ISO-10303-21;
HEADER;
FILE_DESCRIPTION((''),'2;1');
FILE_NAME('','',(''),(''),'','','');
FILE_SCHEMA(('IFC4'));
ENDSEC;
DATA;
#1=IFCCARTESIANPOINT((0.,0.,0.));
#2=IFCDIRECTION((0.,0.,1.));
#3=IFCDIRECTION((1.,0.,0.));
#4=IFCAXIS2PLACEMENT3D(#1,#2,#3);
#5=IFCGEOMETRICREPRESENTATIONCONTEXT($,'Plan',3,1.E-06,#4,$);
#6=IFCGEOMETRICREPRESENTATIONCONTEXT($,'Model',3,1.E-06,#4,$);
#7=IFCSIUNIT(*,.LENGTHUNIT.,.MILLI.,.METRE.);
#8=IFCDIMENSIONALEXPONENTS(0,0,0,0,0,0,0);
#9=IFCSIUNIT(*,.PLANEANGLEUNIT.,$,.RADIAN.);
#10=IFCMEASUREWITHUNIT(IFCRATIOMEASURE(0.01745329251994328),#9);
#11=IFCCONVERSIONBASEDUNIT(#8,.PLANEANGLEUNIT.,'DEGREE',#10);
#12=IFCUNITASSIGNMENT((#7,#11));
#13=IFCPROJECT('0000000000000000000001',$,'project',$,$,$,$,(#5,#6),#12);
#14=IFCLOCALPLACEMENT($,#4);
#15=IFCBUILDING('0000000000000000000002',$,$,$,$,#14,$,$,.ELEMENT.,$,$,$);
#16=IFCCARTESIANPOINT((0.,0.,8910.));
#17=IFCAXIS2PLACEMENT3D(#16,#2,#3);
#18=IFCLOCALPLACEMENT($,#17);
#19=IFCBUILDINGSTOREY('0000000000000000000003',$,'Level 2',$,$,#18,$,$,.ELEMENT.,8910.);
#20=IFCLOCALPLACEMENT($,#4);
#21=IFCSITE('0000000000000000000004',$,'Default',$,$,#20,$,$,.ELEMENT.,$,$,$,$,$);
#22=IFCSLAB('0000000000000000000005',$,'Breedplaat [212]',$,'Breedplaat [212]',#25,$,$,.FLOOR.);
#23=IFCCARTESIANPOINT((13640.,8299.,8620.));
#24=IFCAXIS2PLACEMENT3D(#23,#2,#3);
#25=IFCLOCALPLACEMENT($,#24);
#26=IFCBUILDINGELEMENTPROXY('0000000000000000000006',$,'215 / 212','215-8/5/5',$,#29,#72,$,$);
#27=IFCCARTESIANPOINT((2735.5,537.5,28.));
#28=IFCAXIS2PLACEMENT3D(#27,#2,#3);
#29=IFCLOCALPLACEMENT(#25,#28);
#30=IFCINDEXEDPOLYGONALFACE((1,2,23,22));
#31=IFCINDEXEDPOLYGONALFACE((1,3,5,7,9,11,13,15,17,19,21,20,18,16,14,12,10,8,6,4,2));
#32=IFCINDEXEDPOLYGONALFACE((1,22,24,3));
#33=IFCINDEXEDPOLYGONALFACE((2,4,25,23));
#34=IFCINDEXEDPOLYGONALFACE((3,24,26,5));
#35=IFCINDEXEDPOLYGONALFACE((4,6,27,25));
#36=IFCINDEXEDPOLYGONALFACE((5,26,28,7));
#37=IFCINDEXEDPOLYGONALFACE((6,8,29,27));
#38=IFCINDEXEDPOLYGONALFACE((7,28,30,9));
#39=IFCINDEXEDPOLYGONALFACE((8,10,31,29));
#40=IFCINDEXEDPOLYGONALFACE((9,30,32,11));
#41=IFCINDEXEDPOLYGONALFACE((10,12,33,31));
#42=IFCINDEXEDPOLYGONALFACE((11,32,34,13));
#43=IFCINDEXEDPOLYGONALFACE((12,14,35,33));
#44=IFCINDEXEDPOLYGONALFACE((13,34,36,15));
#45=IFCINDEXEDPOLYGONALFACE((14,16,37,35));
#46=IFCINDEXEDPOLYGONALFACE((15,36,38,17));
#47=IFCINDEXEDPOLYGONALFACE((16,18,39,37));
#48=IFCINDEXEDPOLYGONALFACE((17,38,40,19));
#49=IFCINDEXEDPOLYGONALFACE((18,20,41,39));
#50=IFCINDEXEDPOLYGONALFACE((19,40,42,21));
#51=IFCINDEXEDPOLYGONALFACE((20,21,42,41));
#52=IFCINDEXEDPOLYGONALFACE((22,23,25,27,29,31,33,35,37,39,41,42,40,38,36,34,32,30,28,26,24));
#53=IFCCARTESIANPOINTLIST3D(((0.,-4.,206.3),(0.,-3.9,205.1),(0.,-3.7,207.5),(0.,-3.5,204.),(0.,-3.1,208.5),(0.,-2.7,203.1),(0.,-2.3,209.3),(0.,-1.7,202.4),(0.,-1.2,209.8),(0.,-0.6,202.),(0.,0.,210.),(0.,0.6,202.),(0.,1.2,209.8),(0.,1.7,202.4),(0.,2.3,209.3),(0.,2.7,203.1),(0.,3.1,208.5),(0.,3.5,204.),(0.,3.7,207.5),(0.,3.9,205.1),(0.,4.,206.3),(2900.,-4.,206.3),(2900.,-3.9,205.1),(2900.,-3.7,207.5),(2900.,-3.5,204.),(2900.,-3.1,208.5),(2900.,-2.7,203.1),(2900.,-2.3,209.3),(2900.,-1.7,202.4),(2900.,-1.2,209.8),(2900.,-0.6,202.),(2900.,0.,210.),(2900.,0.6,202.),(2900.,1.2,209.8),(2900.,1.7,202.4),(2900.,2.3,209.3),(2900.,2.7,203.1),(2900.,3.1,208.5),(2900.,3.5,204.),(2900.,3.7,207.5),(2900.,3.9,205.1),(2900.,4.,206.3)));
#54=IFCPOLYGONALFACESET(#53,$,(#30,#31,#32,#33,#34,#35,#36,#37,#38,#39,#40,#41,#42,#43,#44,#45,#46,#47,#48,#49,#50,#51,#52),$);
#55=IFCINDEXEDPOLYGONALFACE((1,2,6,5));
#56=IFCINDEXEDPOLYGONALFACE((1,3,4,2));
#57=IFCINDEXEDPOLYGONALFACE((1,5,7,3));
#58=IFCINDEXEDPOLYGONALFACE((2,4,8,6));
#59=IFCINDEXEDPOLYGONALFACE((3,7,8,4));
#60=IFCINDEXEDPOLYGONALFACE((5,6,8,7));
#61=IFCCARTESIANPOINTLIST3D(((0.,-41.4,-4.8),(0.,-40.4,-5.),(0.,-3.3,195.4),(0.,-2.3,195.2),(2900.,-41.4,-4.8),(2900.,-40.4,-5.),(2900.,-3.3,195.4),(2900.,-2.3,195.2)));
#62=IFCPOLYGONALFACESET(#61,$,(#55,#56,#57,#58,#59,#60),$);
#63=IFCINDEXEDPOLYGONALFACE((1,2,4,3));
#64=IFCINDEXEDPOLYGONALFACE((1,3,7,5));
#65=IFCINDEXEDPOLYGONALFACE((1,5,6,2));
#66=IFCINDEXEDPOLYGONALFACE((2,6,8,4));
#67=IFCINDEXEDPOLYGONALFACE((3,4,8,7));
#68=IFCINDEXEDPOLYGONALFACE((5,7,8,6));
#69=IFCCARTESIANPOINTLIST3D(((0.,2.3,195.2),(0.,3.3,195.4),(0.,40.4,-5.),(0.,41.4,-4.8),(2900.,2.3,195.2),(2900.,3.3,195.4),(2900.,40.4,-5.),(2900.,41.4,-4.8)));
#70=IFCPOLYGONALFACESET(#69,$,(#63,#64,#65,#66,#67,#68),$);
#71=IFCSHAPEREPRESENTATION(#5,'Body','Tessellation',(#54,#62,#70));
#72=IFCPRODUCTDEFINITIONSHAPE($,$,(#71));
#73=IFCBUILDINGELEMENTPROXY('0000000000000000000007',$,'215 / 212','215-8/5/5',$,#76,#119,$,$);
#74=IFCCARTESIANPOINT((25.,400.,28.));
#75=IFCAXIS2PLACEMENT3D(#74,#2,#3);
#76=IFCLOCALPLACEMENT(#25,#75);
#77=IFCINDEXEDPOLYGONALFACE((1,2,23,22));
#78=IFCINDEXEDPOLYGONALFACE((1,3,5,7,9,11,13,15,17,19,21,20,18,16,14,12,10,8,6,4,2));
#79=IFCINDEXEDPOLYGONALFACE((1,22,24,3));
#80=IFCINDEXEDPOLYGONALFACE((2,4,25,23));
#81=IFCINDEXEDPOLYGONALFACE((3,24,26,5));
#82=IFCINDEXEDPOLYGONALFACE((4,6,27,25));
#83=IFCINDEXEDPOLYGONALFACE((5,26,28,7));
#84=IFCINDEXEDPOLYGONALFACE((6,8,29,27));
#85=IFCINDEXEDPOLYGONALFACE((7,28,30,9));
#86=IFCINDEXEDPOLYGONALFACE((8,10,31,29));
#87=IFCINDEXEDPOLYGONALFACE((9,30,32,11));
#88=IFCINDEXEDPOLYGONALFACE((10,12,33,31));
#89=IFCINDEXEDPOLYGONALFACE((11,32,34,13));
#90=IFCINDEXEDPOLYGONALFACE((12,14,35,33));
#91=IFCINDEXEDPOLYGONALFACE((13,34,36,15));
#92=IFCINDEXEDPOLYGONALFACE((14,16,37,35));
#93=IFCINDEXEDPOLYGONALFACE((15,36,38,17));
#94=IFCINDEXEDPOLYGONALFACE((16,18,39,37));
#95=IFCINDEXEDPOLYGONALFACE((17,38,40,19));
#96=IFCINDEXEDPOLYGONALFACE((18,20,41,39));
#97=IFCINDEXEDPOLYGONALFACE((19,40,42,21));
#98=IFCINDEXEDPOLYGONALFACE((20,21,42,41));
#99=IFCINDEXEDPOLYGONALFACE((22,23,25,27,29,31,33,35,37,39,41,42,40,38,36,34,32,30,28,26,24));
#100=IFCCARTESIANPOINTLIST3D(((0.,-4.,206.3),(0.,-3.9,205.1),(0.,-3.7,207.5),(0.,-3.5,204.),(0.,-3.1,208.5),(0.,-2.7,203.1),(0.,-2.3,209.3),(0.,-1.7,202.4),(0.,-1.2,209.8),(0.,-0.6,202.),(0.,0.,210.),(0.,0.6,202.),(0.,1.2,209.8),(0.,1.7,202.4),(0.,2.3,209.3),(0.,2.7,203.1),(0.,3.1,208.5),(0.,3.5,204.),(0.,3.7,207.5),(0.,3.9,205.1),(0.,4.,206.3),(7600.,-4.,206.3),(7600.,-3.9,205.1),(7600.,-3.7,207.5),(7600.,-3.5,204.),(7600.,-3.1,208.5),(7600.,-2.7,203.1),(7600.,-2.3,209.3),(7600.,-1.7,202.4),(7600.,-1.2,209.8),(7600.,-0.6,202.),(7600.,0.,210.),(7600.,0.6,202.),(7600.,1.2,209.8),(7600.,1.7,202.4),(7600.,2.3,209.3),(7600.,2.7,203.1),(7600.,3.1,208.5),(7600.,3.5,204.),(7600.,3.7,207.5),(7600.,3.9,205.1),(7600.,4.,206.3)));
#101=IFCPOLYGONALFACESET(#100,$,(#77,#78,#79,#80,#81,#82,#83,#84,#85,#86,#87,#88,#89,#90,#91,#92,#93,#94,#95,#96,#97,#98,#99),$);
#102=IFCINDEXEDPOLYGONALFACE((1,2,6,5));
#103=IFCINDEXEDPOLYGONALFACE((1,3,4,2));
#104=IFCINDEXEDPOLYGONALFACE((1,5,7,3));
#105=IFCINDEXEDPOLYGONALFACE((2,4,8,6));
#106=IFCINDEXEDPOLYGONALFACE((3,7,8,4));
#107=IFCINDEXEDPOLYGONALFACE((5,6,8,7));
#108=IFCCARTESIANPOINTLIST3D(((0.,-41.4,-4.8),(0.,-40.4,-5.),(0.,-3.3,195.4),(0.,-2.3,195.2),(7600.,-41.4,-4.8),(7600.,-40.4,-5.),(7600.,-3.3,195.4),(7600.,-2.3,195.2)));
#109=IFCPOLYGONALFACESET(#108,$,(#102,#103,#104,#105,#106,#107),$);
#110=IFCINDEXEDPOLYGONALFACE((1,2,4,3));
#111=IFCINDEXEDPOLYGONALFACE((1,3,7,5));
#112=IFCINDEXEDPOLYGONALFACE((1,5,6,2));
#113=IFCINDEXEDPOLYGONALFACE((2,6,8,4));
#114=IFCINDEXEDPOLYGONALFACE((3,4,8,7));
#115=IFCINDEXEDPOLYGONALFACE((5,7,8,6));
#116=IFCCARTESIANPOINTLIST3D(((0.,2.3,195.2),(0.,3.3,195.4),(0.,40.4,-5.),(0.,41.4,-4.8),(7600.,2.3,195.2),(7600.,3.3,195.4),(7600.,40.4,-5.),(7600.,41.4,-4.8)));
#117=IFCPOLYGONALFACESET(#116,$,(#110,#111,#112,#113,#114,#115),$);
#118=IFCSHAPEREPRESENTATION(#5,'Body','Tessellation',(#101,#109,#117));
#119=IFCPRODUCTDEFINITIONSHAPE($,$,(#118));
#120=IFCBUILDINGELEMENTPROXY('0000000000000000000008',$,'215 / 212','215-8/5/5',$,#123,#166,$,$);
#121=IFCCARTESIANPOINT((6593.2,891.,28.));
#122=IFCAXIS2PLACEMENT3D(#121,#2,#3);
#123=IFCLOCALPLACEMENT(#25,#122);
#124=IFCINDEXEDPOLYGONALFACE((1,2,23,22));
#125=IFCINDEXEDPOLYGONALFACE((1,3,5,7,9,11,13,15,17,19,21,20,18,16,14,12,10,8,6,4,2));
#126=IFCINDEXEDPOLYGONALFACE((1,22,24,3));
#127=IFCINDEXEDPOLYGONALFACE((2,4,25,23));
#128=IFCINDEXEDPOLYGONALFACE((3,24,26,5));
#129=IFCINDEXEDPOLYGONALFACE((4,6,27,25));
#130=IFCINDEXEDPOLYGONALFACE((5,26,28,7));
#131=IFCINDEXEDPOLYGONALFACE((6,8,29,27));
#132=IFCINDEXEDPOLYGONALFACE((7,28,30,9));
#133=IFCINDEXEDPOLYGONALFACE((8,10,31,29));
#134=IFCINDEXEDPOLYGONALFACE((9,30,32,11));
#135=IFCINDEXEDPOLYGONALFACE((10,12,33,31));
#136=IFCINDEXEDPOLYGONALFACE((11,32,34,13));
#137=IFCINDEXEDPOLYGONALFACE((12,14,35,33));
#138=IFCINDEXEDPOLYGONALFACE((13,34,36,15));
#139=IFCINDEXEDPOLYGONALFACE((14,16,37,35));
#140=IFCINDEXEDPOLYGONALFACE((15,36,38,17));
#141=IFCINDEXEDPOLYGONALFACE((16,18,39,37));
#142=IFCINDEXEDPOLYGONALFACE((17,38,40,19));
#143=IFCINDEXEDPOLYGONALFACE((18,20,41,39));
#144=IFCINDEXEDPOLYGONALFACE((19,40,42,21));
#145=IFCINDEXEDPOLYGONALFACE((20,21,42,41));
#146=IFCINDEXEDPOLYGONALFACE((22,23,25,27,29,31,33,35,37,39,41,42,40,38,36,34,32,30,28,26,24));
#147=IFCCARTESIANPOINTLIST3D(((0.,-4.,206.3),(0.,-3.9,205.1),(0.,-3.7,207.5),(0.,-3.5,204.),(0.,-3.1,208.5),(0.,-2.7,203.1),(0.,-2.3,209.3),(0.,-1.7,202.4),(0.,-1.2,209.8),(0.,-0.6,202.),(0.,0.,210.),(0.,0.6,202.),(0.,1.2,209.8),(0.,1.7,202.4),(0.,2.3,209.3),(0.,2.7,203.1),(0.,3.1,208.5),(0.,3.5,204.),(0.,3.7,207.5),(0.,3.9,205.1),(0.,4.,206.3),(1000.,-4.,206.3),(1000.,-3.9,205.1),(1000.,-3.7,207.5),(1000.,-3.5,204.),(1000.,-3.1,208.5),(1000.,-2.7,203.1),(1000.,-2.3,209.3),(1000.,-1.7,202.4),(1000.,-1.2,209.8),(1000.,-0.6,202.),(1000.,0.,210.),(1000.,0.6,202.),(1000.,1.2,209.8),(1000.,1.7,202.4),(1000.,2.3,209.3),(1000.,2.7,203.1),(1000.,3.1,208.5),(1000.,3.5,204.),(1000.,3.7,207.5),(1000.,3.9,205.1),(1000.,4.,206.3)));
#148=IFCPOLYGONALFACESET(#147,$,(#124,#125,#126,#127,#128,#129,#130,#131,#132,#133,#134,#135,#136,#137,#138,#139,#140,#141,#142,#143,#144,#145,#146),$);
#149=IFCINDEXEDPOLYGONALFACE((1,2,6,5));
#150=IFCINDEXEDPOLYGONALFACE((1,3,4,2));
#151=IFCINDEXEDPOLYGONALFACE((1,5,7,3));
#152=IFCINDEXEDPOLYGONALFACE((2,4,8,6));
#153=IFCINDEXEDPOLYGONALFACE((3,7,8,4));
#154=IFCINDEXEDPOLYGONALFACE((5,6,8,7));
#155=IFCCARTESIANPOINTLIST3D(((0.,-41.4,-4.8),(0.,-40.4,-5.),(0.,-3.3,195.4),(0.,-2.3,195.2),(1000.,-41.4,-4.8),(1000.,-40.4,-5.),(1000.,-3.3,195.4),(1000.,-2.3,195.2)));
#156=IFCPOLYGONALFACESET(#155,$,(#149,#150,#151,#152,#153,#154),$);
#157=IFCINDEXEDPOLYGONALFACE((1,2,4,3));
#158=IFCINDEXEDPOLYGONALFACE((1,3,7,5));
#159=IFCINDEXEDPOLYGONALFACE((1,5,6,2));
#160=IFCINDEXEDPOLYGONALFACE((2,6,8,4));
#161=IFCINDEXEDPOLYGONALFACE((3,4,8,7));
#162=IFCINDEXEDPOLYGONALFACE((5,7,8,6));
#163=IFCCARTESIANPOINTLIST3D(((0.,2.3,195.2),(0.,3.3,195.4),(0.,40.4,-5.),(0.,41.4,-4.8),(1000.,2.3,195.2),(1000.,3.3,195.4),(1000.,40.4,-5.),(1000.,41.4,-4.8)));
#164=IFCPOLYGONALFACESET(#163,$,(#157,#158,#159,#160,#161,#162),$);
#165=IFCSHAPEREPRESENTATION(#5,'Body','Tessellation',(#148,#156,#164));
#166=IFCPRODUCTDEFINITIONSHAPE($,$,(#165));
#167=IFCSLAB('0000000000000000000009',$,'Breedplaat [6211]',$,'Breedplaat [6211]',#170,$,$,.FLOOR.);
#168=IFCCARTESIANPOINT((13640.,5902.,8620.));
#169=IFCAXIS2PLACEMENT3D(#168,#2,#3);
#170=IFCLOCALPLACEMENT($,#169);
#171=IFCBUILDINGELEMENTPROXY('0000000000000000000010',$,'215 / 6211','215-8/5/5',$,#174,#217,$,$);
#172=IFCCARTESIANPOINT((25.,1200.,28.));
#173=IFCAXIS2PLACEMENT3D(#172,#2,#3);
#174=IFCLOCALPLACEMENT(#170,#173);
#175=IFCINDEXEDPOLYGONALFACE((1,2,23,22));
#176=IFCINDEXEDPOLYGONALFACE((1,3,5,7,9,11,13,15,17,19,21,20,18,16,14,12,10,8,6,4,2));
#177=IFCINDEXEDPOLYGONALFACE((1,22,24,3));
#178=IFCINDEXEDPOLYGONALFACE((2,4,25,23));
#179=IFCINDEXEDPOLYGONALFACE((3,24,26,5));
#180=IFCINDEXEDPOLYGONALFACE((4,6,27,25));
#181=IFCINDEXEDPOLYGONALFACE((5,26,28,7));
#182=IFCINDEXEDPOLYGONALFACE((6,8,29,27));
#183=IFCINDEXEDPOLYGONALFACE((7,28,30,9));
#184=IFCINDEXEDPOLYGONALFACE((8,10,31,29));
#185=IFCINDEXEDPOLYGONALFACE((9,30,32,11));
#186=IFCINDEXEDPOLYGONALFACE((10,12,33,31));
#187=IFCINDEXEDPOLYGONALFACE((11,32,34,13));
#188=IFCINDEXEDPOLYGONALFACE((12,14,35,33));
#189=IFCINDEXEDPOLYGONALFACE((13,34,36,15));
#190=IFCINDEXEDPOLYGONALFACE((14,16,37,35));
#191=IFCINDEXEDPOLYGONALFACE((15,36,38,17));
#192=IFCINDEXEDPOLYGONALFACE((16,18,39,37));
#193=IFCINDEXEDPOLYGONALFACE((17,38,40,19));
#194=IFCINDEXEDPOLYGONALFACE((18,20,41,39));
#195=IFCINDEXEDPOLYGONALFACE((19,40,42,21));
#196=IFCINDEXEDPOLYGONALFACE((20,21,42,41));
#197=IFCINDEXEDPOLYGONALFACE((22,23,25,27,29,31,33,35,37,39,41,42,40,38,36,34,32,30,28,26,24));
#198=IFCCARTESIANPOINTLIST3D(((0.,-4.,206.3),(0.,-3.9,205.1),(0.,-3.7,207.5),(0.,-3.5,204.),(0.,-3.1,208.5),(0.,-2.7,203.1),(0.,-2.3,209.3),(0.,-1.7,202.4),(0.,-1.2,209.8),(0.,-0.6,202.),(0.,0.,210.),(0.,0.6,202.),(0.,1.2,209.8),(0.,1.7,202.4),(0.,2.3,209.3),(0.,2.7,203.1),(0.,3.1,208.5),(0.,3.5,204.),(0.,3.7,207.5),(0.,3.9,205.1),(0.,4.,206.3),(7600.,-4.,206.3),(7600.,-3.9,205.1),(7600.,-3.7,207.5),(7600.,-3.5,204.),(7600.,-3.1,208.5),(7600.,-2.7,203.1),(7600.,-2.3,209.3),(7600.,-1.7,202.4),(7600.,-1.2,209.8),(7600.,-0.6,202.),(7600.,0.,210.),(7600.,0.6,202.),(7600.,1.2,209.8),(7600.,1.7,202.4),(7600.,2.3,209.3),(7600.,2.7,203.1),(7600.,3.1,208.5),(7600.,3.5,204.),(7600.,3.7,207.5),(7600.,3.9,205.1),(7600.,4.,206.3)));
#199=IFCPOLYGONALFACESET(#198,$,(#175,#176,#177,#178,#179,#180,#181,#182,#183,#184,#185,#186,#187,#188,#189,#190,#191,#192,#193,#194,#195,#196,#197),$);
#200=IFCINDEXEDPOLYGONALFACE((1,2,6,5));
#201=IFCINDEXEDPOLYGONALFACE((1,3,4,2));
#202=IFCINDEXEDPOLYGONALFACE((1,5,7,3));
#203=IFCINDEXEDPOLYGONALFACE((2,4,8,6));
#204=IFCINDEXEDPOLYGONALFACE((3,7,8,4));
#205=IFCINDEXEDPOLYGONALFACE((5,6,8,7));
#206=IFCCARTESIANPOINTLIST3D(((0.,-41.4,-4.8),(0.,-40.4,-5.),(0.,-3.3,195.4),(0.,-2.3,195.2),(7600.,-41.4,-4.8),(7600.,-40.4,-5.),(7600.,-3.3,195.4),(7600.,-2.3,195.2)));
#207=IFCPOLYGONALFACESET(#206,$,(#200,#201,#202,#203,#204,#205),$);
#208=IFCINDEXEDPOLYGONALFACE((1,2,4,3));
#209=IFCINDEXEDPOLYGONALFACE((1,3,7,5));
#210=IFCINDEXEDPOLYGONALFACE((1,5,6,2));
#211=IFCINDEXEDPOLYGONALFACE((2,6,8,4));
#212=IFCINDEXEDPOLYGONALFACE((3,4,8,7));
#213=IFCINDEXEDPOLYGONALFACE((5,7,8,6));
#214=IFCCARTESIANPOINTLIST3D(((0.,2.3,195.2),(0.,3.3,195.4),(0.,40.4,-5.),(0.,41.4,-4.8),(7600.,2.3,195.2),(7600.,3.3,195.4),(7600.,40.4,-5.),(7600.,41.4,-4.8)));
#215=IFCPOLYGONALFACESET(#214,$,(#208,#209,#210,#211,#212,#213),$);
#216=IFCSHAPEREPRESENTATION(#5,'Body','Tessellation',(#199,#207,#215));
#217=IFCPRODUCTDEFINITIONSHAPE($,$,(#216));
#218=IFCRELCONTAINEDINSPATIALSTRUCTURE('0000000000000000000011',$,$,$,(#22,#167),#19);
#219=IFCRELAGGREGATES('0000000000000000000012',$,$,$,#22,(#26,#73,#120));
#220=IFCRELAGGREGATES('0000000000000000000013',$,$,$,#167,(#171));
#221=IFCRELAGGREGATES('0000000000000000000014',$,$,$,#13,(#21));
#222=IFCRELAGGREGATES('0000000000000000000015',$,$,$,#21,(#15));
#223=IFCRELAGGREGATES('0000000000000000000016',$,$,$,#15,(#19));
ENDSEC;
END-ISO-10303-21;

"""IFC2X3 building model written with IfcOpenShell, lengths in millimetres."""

from ifc_helpers import new_model, entity, si_unit, converted_unit, frame, origin_with_axes, origin_2d_with_axis, place, context, project, spatial, rectangle, circle, extrude, element, aggregate, save


model = new_model("IFC2X3")

# Units and contexts
plan_context = context("Plan", 3, precision=1e-06, world=origin_with_axes())
model_context = context("Model", 3, precision=1e-06, world=origin_with_axes())
ifc_project = project(units=[si_unit("LENGTHUNIT", "METRE", prefix="MILLI"), converted_unit("PLANEANGLEUNIT", "DEGREE", entity("IfcRatioMeasure", 0.01745329251994328), si_unit("PLANEANGLEUNIT", "RADIAN"), dimensions=[0, 0, 0, 0, 0, 0, 0])], contexts=[plan_context, model_context])

# Site, building, storey
site_placement = place(None, origin_with_axes())
site = spatial("IfcSite", under=ifc_project, at=site_placement, Name="Default", CompositionType="ELEMENT")
building_placement = place(None, origin_with_axes())
building = spatial("IfcBuilding", under=site, at=building_placement, CompositionType="ELEMENT")
storey_placement = place(None, frame((0.0, 0.0, 8910.0), z_axis=(0.0, 0.0, 1.0), x_axis=(1.0, 0.0, 0.0)))
storey = spatial("IfcBuildingStorey", under=building, at=storey_placement, Name="Level 2", CompositionType="ELEMENT", Elevation=8910.0)

# Slab, building element proxies
slab_1_placement = place(None, frame((13640.0, 8299.0, 8620.0), z_axis=(0.0, 0.0, 1.0), x_axis=(1.0, 0.0, 0.0)))
slab_1 = element("IfcSlab", 1, at=slab_1_placement, inside=storey, Name="Breedplaat [212]", ObjectType="Breedplaat [212]", PredefinedType="FLOOR")
proxy_1_placement = place(slab_1_placement, frame((2735.5, 537.5, 28.0), z_axis=(0.0, 0.0, 1.0), x_axis=(1.0, 0.0, 0.0)))
proxy_1 = element("IfcBuildingElementProxy", 2, at=proxy_1_placement, Name="215 / 212", Description="215-8/5/5", context=plan_context, shape_type="SweptSolid", body=[
    extrude(circle(Radius=4.0, at=origin_2d_with_axis()), frame((0.0, 0.0, 206.0), z_axis=(1.0, 0.0, 0.0), x_axis=(0.0, 0.0, 1.0)), (0.0, 0.0, 1.0), 2900.0),
    extrude(rectangle(XDim=203.8, YDim=1.0, at=origin_2d_with_axis()), frame((0.0, -21.9, 95.2), z_axis=(1.0, 0.0, 0.0), x_axis=(0.0, 0.187112, 0.982339)), (0.0, 0.0, 1.0), 2900.0),
    extrude(rectangle(XDim=203.8, YDim=1.0, at=origin_2d_with_axis()), frame((0.0, 21.9, 95.2), z_axis=(1.0, 0.0, 0.0), x_axis=(0.0, -0.187112, 0.982339)), (0.0, 0.0, 1.0), 2900.0),
])
proxy_2_placement = place(slab_1_placement, frame((25.0, 400.0, 28.0), z_axis=(0.0, 0.0, 1.0), x_axis=(1.0, 0.0, 0.0)))
proxy_2 = element("IfcBuildingElementProxy", 3, at=proxy_2_placement, Name="215 / 212", Description="215-8/5/5", context=plan_context, shape_type="SweptSolid", body=[
    extrude(circle(Radius=4.0, at=origin_2d_with_axis()), frame((0.0, 0.0, 206.0), z_axis=(1.0, 0.0, 0.0), x_axis=(0.0, 0.0, 1.0)), (0.0, 0.0, 1.0), 7600.0),
    extrude(rectangle(XDim=203.8, YDim=1.0, at=origin_2d_with_axis()), frame((0.0, -21.9, 95.2), z_axis=(1.0, 0.0, 0.0), x_axis=(0.0, 0.187112, 0.982339)), (0.0, 0.0, 1.0), 7600.0),
    extrude(rectangle(XDim=203.8, YDim=1.0, at=origin_2d_with_axis()), frame((0.0, 21.9, 95.2), z_axis=(1.0, 0.0, 0.0), x_axis=(0.0, -0.187112, 0.982339)), (0.0, 0.0, 1.0), 7600.0),
])
proxy_3_placement = place(slab_1_placement, frame((6593.2, 891.0, 28.0), z_axis=(0.0, 0.0, 1.0), x_axis=(1.0, 0.0, 0.0)))
proxy_3 = element("IfcBuildingElementProxy", 4, at=proxy_3_placement, Name="215 / 212", Description="215-8/5/5", context=plan_context, shape_type="SweptSolid", body=[
    extrude(circle(Radius=4.0, at=origin_2d_with_axis()), frame((0.0, 0.0, 206.0), z_axis=(1.0, 0.0, 0.0), x_axis=(0.0, 0.0, 1.0)), (0.0, 0.0, 1.0), 1000.0),
    extrude(rectangle(XDim=203.8, YDim=1.0, at=origin_2d_with_axis()), frame((0.0, -21.9, 95.2), z_axis=(1.0, 0.0, 0.0), x_axis=(0.0, 0.187112, 0.982339)), (0.0, 0.0, 1.0), 1000.0),
    extrude(rectangle(XDim=203.8, YDim=1.0, at=origin_2d_with_axis()), frame((0.0, 21.9, 95.2), z_axis=(1.0, 0.0, 0.0), x_axis=(0.0, -0.187112, 0.982339)), (0.0, 0.0, 1.0), 1000.0),
])
aggregate(slab_1, [proxy_1, proxy_2, proxy_3])

# Slab, building element proxy
slab_2_placement = place(None, frame((13640.0, 5902.0, 8620.0), z_axis=(0.0, 0.0, 1.0), x_axis=(1.0, 0.0, 0.0)))
slab_2 = element("IfcSlab", 5, at=slab_2_placement, inside=storey, Name="Breedplaat [6211]", ObjectType="Breedplaat [6211]", PredefinedType="FLOOR")
proxy_4_placement = place(slab_2_placement, frame((25.0, 1200.0, 28.0), z_axis=(0.0, 0.0, 1.0), x_axis=(1.0, 0.0, 0.0)))
proxy_4 = element("IfcBuildingElementProxy", 6, at=proxy_4_placement, Name="215 / 6211", Description="215-8/5/5", context=plan_context, shape_type="SweptSolid", body=[
    extrude(circle(Radius=4.0, at=origin_2d_with_axis()), frame((0.0, 0.0, 206.0), z_axis=(1.0, 0.0, 0.0), x_axis=(0.0, 0.0, 1.0)), (0.0, 0.0, 1.0), 7600.0),
    extrude(rectangle(XDim=203.8, YDim=1.0, at=origin_2d_with_axis()), frame((0.0, -21.9, 95.2), z_axis=(1.0, 0.0, 0.0), x_axis=(0.0, 0.187112, 0.982339)), (0.0, 0.0, 1.0), 7600.0),
    extrude(rectangle(XDim=203.8, YDim=1.0, at=origin_2d_with_axis()), frame((0.0, 21.9, 95.2), z_axis=(1.0, 0.0, 0.0), x_axis=(0.0, -0.187112, 0.982339)), (0.0, 0.0, 1.0), 7600.0),
])
aggregate(slab_2, [proxy_4])

save(model, "model.ifc")
